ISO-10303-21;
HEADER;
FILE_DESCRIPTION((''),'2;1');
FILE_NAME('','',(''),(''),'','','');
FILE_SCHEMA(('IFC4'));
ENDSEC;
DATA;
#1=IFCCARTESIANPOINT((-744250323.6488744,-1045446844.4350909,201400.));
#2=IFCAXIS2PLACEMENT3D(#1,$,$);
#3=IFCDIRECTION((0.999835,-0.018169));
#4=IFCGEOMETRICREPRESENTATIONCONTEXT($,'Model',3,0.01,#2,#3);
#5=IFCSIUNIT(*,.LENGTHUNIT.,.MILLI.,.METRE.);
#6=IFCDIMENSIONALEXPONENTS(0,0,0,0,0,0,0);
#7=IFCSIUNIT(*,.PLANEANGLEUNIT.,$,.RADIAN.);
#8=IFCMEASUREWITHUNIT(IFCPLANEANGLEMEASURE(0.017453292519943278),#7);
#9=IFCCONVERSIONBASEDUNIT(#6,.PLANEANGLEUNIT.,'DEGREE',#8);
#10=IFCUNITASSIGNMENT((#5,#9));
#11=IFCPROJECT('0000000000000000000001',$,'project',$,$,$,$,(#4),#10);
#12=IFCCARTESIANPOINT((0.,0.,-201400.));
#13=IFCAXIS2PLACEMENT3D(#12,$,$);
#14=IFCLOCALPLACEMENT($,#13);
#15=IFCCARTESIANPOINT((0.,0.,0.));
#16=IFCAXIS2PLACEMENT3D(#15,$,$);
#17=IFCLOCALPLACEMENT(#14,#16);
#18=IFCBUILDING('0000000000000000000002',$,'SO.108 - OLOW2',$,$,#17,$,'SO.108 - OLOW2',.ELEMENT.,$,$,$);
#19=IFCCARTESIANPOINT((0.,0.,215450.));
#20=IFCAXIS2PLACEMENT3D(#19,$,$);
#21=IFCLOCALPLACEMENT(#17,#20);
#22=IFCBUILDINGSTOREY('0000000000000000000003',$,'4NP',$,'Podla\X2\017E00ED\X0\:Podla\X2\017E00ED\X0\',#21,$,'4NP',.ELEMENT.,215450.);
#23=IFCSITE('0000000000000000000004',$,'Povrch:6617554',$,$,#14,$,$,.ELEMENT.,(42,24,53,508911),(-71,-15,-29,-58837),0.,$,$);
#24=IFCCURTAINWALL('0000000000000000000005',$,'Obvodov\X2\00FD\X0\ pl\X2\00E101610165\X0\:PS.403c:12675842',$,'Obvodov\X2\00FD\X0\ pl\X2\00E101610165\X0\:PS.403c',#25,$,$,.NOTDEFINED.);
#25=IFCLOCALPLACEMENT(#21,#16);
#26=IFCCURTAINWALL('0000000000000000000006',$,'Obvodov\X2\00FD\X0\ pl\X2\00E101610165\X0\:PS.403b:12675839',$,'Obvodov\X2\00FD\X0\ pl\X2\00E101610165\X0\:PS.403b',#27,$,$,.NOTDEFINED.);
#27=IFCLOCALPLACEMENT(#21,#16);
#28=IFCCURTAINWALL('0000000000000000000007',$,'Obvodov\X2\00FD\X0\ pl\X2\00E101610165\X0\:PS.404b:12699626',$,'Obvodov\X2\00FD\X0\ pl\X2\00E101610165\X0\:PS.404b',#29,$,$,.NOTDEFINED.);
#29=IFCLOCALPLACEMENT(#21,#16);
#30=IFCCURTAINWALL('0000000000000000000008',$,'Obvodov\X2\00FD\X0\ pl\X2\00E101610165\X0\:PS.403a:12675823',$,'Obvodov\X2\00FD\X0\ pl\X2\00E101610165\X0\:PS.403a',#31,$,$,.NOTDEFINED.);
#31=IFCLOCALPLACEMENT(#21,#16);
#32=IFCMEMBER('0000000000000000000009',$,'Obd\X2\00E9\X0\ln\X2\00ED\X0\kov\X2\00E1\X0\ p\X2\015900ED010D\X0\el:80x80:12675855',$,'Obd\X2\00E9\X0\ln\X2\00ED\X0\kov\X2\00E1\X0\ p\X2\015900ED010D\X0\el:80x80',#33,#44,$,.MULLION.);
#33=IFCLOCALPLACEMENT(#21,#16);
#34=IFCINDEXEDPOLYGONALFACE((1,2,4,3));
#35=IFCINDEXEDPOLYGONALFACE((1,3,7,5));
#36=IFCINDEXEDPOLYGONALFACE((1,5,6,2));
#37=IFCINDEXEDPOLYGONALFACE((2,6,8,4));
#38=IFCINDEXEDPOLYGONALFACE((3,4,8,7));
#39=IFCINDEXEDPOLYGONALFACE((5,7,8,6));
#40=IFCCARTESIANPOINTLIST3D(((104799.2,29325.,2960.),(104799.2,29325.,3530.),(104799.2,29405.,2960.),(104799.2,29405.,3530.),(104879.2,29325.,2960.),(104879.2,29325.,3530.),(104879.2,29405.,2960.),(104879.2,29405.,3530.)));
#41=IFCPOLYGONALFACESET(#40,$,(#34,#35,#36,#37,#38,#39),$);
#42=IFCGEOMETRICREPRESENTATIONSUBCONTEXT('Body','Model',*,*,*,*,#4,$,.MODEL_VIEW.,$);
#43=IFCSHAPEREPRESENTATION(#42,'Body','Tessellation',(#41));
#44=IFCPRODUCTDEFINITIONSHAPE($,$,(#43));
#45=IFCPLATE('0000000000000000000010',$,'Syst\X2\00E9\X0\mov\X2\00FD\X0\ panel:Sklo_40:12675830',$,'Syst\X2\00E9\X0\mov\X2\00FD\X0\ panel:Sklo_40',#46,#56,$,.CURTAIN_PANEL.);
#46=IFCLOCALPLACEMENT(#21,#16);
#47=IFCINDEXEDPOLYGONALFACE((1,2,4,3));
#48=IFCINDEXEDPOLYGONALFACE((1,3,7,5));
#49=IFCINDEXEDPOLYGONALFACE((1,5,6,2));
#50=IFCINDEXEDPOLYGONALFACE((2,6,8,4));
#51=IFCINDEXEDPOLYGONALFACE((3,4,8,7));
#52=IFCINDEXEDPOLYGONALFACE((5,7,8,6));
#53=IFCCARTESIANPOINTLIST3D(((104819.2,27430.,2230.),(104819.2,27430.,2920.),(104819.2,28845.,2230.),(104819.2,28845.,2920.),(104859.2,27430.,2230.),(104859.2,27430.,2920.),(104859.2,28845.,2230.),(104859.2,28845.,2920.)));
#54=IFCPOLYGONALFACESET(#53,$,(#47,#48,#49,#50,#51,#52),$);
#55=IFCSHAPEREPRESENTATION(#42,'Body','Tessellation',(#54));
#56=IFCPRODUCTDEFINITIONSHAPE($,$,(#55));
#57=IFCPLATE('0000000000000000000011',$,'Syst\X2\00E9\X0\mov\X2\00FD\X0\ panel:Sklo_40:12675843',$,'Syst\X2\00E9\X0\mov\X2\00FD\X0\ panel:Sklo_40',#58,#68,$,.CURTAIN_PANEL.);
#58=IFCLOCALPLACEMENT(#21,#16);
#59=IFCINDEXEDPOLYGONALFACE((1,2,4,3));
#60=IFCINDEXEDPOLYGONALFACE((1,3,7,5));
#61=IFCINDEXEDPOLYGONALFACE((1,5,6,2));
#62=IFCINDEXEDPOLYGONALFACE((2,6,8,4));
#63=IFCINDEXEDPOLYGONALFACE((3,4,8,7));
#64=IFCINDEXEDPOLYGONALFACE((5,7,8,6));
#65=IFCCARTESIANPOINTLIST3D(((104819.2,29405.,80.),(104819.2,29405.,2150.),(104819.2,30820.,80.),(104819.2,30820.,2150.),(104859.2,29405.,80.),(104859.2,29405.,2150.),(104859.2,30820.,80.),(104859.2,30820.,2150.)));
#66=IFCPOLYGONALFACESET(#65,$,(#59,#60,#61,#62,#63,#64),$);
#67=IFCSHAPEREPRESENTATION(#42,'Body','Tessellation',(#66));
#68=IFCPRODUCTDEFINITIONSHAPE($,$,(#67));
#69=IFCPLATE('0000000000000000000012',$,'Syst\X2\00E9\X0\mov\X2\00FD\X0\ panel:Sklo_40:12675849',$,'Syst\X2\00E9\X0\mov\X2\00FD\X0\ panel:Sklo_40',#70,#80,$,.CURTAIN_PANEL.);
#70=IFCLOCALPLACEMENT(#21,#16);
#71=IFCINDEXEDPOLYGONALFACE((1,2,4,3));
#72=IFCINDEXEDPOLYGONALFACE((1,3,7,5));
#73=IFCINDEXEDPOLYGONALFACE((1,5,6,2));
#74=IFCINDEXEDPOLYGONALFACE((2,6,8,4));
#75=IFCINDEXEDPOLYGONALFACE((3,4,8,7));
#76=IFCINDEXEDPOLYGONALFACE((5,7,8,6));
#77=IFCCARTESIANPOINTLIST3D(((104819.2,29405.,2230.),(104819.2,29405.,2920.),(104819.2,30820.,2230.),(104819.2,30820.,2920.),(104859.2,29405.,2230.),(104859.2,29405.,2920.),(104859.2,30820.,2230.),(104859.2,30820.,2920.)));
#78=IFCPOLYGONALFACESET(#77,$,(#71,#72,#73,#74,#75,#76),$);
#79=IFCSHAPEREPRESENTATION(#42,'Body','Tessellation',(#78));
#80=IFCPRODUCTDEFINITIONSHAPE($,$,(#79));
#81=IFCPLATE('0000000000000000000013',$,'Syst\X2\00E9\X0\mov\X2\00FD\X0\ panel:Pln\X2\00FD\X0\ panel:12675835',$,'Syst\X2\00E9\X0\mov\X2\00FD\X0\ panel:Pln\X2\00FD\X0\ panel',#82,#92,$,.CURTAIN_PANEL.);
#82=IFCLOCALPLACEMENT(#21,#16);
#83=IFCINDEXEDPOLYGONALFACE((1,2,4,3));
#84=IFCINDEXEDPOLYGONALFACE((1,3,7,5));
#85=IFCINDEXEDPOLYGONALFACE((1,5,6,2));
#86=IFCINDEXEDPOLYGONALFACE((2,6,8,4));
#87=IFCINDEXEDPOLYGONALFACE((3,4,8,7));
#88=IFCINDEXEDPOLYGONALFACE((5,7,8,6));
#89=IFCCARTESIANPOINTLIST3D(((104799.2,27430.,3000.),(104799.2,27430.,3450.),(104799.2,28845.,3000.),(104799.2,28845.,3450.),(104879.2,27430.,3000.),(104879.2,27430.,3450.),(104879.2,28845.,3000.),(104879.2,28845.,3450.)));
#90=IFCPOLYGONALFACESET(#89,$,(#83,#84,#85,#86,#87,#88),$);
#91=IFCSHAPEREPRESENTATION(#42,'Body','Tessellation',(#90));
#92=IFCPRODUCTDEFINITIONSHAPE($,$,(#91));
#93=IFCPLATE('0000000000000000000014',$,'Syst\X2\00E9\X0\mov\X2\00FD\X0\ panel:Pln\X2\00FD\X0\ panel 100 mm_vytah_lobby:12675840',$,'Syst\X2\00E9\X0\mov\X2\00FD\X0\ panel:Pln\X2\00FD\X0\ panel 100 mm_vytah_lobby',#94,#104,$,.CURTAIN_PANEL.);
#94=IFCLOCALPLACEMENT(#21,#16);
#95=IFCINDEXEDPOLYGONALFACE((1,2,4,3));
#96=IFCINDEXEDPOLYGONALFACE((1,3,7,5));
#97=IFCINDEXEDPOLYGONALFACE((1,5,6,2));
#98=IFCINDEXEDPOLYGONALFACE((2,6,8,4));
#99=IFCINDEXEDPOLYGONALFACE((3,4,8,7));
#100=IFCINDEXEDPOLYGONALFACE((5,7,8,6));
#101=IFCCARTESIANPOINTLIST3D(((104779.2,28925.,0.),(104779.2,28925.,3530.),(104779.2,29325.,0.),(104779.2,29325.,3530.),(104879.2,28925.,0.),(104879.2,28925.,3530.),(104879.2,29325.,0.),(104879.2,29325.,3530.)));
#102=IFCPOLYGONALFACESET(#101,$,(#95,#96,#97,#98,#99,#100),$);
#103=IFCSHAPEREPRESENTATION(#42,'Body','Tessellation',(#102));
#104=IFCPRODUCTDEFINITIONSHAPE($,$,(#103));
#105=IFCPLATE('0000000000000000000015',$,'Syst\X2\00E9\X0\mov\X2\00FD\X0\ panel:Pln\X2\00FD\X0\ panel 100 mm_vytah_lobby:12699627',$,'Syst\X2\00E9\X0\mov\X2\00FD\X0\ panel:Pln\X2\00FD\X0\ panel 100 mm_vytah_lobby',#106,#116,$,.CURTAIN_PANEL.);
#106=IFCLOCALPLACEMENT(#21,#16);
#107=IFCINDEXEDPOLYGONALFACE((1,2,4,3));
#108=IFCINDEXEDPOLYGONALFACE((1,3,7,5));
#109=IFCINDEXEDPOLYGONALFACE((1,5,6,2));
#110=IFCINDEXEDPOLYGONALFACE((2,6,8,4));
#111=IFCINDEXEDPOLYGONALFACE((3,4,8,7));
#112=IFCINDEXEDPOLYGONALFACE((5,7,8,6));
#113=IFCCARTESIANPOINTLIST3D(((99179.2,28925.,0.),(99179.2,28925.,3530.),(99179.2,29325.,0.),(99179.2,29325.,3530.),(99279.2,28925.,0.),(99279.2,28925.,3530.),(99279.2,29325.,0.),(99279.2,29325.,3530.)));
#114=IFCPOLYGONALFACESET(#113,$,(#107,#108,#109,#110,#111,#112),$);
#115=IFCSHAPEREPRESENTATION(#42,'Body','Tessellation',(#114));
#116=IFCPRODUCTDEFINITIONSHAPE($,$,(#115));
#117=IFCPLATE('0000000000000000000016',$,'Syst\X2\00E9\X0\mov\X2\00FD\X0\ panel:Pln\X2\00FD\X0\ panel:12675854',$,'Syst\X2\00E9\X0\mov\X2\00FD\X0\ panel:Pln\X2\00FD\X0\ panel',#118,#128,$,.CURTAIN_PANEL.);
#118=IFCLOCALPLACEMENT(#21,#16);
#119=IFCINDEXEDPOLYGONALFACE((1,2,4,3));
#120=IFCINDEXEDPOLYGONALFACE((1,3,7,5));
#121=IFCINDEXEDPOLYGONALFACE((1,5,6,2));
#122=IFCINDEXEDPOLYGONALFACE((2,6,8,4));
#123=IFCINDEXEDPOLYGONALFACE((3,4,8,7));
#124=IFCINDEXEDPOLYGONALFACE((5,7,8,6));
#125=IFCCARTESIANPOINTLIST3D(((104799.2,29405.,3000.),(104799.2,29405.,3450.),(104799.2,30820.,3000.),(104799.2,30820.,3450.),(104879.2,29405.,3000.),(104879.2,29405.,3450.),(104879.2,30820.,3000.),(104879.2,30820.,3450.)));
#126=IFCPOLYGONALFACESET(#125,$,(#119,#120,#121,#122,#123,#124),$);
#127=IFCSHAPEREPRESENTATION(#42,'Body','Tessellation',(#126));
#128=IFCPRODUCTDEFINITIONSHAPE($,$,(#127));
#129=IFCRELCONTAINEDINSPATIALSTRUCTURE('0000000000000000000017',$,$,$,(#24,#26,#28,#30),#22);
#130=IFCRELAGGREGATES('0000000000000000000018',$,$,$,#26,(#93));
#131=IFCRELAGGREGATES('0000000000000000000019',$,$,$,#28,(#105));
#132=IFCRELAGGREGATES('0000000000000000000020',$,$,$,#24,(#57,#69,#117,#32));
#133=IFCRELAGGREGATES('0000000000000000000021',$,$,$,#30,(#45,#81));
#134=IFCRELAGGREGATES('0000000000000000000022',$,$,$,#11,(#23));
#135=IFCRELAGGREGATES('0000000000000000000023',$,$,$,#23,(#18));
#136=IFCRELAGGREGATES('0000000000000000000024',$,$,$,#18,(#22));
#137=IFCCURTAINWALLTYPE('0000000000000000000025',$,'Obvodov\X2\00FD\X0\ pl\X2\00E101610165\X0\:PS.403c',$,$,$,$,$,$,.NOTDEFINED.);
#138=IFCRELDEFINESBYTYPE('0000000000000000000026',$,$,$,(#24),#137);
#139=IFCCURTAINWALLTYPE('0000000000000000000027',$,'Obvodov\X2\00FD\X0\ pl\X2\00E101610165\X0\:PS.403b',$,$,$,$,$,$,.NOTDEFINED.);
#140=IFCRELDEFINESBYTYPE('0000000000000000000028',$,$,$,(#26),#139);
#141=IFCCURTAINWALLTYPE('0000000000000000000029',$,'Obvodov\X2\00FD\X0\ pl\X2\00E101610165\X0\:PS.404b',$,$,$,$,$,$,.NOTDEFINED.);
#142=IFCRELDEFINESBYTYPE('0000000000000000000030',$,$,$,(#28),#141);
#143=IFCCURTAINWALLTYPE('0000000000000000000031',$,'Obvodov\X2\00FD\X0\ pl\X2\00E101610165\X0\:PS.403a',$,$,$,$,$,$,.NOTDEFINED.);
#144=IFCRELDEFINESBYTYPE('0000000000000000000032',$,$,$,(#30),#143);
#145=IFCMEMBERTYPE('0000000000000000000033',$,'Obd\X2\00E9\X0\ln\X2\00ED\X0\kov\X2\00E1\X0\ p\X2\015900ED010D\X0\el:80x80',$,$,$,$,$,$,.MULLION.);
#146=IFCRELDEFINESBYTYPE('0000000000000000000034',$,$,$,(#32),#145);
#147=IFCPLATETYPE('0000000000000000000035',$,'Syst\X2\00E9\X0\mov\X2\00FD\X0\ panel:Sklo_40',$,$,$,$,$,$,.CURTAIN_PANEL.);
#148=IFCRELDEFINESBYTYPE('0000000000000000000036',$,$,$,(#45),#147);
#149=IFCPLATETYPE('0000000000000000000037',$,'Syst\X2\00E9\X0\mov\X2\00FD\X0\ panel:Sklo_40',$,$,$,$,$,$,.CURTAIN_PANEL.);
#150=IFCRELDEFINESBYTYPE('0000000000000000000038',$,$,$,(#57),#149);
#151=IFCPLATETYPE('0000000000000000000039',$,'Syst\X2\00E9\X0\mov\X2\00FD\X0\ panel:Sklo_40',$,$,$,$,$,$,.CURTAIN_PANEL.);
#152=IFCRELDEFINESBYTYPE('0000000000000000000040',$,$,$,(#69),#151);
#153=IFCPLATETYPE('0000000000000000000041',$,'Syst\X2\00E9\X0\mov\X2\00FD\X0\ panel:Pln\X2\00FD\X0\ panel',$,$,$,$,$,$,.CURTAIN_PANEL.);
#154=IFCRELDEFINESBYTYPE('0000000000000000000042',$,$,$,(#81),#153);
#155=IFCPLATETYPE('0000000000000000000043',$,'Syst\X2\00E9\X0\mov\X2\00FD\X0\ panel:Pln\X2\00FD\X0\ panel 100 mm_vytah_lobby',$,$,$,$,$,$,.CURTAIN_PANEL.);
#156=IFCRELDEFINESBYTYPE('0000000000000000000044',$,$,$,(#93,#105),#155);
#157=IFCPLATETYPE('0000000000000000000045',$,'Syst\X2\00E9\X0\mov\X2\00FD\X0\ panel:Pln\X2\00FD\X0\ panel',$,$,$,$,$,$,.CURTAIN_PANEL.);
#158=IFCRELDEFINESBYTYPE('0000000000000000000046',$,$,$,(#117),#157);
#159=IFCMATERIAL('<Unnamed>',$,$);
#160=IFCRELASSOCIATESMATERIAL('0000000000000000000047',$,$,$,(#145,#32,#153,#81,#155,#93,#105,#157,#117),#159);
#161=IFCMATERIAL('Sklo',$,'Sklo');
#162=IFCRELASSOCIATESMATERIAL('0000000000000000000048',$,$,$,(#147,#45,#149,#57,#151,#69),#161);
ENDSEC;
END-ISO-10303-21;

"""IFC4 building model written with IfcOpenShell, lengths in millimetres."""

from ifc_helpers import new_model, entity, si_unit, converted_unit, direction, frame, origin, place, context, subcontext, project, spatial, indexed_curve, outline, extrude, source, transform, mapped, material, type_object, type_shapes, element, aggregate, save


model = new_model("IFC4")

# Units and contexts
model_context = context("Model", 3, precision=0.01, world=frame((-744250323.6488744, -1045446844.4350909, 201400.0)), true_north=direction((0.999835, -0.018169)))
body_context = subcontext(model_context, "Body", "Model", "MODEL_VIEW")
ifc_project = project(units=[si_unit("LENGTHUNIT", "METRE", prefix="MILLI"), converted_unit("PLANEANGLEUNIT", "DEGREE", entity("IfcPlaneAngleMeasure", 0.017453292519943278), si_unit("PLANEANGLEUNIT", "RADIAN"), dimensions=[0, 0, 0, 0, 0, 0, 0])], contexts=[model_context])

# Site, building, storey
site_placement = place(None, frame((0.0, 0.0, -201400.0)))
site = spatial("IfcSite", under=ifc_project, at=site_placement, Name="Povrch:6617554", CompositionType="ELEMENT", RefLatitude=(42, 24, 53, 508911), RefLongitude=(-71, -15, -29, -58837), RefElevation=0.0)
building_placement = place(site_placement, origin())
building = spatial("IfcBuilding", under=site, at=building_placement, Name="SO.108 - OLOW2", LongName="SO.108 - OLOW2", CompositionType="ELEMENT")
storey_placement = place(building_placement, frame((0.0, 0.0, 215450.0)))
storey = spatial("IfcBuildingStorey", under=building, at=storey_placement, Name="4NP", ObjectType="Podlaží:Podlaží", LongName="4NP", CompositionType="ELEMENT", Elevation=215450.0)

# Curtain wall
curtain_wall_type_1 = type_object("IfcCurtainWallType", Name="Obvodový plášť:PS.403c", PredefinedType="NOTDEFINED")
curtain_wall_1_placement = place(storey_placement, frame((0.0, 0.0, -215450.0)))
curtain_wall_1 = element("IfcCurtainWall", 1, at=curtain_wall_1_placement, inside=storey, type_object=curtain_wall_type_1, Name="Obvodový plášť:PS.403c:12675842", ObjectType="Obvodový plášť:PS.403c", PredefinedType="NOTDEFINED")
ifc_material_1 = material(Name="<Unnamed>")

# Curtain walls
curtain_wall_type_2 = type_object("IfcCurtainWallType", Name="Obvodový plášť:PS.403b", PredefinedType="NOTDEFINED")
curtain_wall_2_placement = place(storey_placement, frame((0.0, 0.0, -215450.0)))
curtain_wall_2 = element("IfcCurtainWall", 2, at=curtain_wall_2_placement, inside=storey, type_object=curtain_wall_type_2, Name="Obvodový plášť:PS.403b:12675839", ObjectType="Obvodový plášť:PS.403b", PredefinedType="NOTDEFINED")
curtain_wall_type_3 = type_object("IfcCurtainWallType", Name="Obvodový plášť:PS.404b", PredefinedType="NOTDEFINED")
curtain_wall_3_placement = place(storey_placement, frame((0.0, 0.0, -215450.0)))
curtain_wall_3 = element("IfcCurtainWall", 3, at=curtain_wall_3_placement, inside=storey, type_object=curtain_wall_type_3, Name="Obvodový plášť:PS.404b:12699626", ObjectType="Obvodový plášť:PS.404b", PredefinedType="NOTDEFINED")

# Curtain wall
curtain_wall_type_4 = type_object("IfcCurtainWallType", Name="Obvodový plášť:PS.403a", PredefinedType="NOTDEFINED")
curtain_wall_4_placement = place(storey_placement, frame((0.0, 0.0, -215450.0)))
curtain_wall_4 = element("IfcCurtainWall", 4, at=curtain_wall_4_placement, inside=storey, type_object=curtain_wall_type_4, Name="Obvodový plášť:PS.403a:12675823", ObjectType="Obvodový plášť:PS.403a", PredefinedType="NOTDEFINED")

# Member
member_type_1 = type_object("IfcMemberType", Name="Obdélníková příčel:80x80", PredefinedType="MULLION", material=ifc_material_1)
shared_shape_1 = source(origin(), body_context, "Body", "SweptSolid", [
    extrude(outline(indexed_curve([(-40.0, -40.0), (40.0, -40.0), (40.0, 40.0), (-40.0, 40.0), (-40.0, -40.0)], self_intersect=False)), frame((-40.0, 0.0, -570.0), z_axis=(0.0, 0.0, 1.0), x_axis=(-1.0, 0.0, 0.0)), (0.0, 0.0, 1.0), 570.0),
])
type_shapes(member_type_1, [shared_shape_1])
member_1_placement = place(curtain_wall_1_placement, frame((104839.2, 29325.0, 218410.0), z_axis=(0.0, 0.0, -1.0), x_axis=(0.0, -1.0, 0.0)))
member_1 = element("IfcMember", 5, at=member_1_placement, type_object=member_type_1, material=ifc_material_1, Name="Obdélníková příčel:80x80:12675855", ObjectType="Obdélníková příčel:80x80", PredefinedType="MULLION", context=body_context, shape_type="MappedRepresentation", body=[
    mapped(shared_shape_1, transform((0.0, 0.0, 0.0), scale=1.0)),
])

# Plates
ifc_material_2 = material(Name="Sklo", Category="Sklo")
plate_type_1 = type_object("IfcPlateType", Name="Systémový panel:Sklo_40", PredefinedType="CURTAIN_PANEL", material=ifc_material_2)
shared_shape_2 = source(origin(), body_context, "Body", "SweptSolid", [
    extrude(outline(indexed_curve([(-20.0, -707.5), (20.0, -707.5), (20.0, 707.5), (-20.0, 707.5), (-20.0, -707.5)], self_intersect=False)), frame((0.0, 0.0, 0.0), z_axis=(0.0, 0.0, 1.0), x_axis=(0.0, 1.0, 0.0)), (0.0, 0.0, 1.0), 690.0),
])
type_shapes(plate_type_1, [shared_shape_2])
plate_1_placement = place(curtain_wall_4_placement, frame((104839.2, 28137.5, 217680.0), z_axis=(0.0, 0.0, 1.0), x_axis=(0.0, -1.0, 0.0)))
plate_1 = element("IfcPlate", 6, at=plate_1_placement, type_object=plate_type_1, material=ifc_material_2, Name="Systémový panel:Sklo_40:12675830", ObjectType="Systémový panel:Sklo_40", PredefinedType="CURTAIN_PANEL", context=body_context, shape_type="MappedRepresentation", body=[
    mapped(shared_shape_2, transform((0.0, 0.0, 0.0), scale=1.0)),
])
plate_type_2 = type_object("IfcPlateType", Name="Systémový panel:Sklo_40", PredefinedType="CURTAIN_PANEL", material=ifc_material_2)
shared_shape_3 = source(origin(), body_context, "Body", "SweptSolid", [
    extrude(outline(indexed_curve([(-20.0, -707.5), (20.0, -707.5), (20.0, 707.5), (-20.0, 707.5), (-20.0, -707.5)], self_intersect=False)), frame((0.0, 0.0, 0.0), z_axis=(0.0, 0.0, 1.0), x_axis=(0.0, 1.0, 0.0)), (0.0, 0.0, 1.0), 2070.0),
])
type_shapes(plate_type_2, [shared_shape_3])
plate_2_placement = place(curtain_wall_1_placement, frame((104839.2, 30112.5, 215530.0), z_axis=(0.0, 0.0, 1.0), x_axis=(0.0, -1.0, 0.0)))
plate_2 = element("IfcPlate", 7, at=plate_2_placement, type_object=plate_type_2, material=ifc_material_2, Name="Systémový panel:Sklo_40:12675843", ObjectType="Systémový panel:Sklo_40", PredefinedType="CURTAIN_PANEL", context=body_context, shape_type="MappedRepresentation", body=[
    mapped(shared_shape_3, transform((0.0, 0.0, 0.0), scale=1.0)),
])
plate_type_3 = type_object("IfcPlateType", Name="Systémový panel:Sklo_40", PredefinedType="CURTAIN_PANEL", material=ifc_material_2)
shared_shape_4 = source(origin(), body_context, "Body", "SweptSolid", [
    extrude(outline(indexed_curve([(-20.0, -707.5), (20.0, -707.5), (20.0, 707.5), (-20.0, 707.5), (-20.0, -707.5)], self_intersect=False)), frame((0.0, 0.0, 0.0), z_axis=(0.0, 0.0, 1.0), x_axis=(0.0, 1.0, 0.0)), (0.0, 0.0, 1.0), 690.0),
])
type_shapes(plate_type_3, [shared_shape_4])
plate_3_placement = place(curtain_wall_1_placement, frame((104839.2, 30112.5, 217680.0), z_axis=(0.0, 0.0, 1.0), x_axis=(0.0, -1.0, 0.0)))
plate_3 = element("IfcPlate", 8, at=plate_3_placement, type_object=plate_type_3, material=ifc_material_2, Name="Systémový panel:Sklo_40:12675849", ObjectType="Systémový panel:Sklo_40", PredefinedType="CURTAIN_PANEL", context=body_context, shape_type="MappedRepresentation", body=[
    mapped(shared_shape_4, transform((0.0, 0.0, 0.0), scale=1.0)),
])
plate_type_4 = type_object("IfcPlateType", Name="Systémový panel:Plný panel", PredefinedType="CURTAIN_PANEL", material=ifc_material_1)
shared_shape_5 = source(origin(), body_context, "Body", "SweptSolid", [
    extrude(outline(indexed_curve([(-40.0, -707.5), (40.0, -707.5), (40.0, 707.5), (-40.0, 707.5), (-40.0, -707.5)], self_intersect=False)), frame((0.0, 0.0, 0.0), z_axis=(0.0, 0.0, 1.0), x_axis=(0.0, 1.0, 0.0)), (0.0, 0.0, 1.0), 450.0),
])
type_shapes(plate_type_4, [shared_shape_5])
plate_4_placement = place(curtain_wall_4_placement, frame((104839.2, 28137.5, 218450.0), z_axis=(0.0, 0.0, 1.0), x_axis=(0.0, -1.0, 0.0)))
plate_4 = element("IfcPlate", 9, at=plate_4_placement, type_object=plate_type_4, material=ifc_material_1, Name="Systémový panel:Plný panel:12675835", ObjectType="Systémový panel:Plný panel", PredefinedType="CURTAIN_PANEL", context=body_context, shape_type="MappedRepresentation", body=[
    mapped(shared_shape_5, transform((0.0, 0.0, 0.0), scale=1.0)),
])
plate_type_5 = type_object("IfcPlateType", Name="Systémový panel:Plný panel 100 mm_vytah_lobby", PredefinedType="CURTAIN_PANEL", material=ifc_material_1)
shared_shape_6 = source(origin(), body_context, "Body", "SweptSolid", [
    extrude(outline(indexed_curve([(-50.0, -200.0), (50.0, -200.0), (50.0, 200.0), (-50.0, 200.0), (-50.0, -200.0)], self_intersect=False)), frame((0.0, 10.0, 0.0), z_axis=(0.0, 0.0, 1.0), x_axis=(0.0, 1.0, 0.0)), (0.0, 0.0, 1.0), 3530.0),
])
type_shapes(plate_type_5, [shared_shape_6])
plate_5_placement = place(curtain_wall_2_placement, frame((104839.2, 29125.0, 215450.0), z_axis=(0.0, 0.0, 1.0), x_axis=(0.0, 1.0, 0.0)))
plate_5 = element("IfcPlate", 10, at=plate_5_placement, type_object=plate_type_5, material=ifc_material_1, Name="Systémový panel:Plný panel 100 mm_vytah_lobby:12675840", ObjectType="Systémový panel:Plný panel 100 mm_vytah_lobby", PredefinedType="CURTAIN_PANEL", context=body_context, shape_type="MappedRepresentation", body=[
    mapped(shared_shape_6, transform((0.0, 0.0, 0.0), scale=1.0)),
])
aggregate(curtain_wall_2, [plate_5])
plate_6_placement = place(curtain_wall_3_placement, frame((99239.2, 29125.0, 215450.0), z_axis=(0.0, 0.0, 1.0), x_axis=(0.0, 1.0, 0.0)))
plate_6 = element("IfcPlate", 11, at=plate_6_placement, type_object=plate_type_5, material=ifc_material_1, Name="Systémový panel:Plný panel 100 mm_vytah_lobby:12699627", ObjectType="Systémový panel:Plný panel 100 mm_vytah_lobby", PredefinedType="CURTAIN_PANEL", context=body_context, shape_type="MappedRepresentation", body=[
    mapped(shared_shape_6, transform((0.0, 0.0, 0.0), scale=1.0)),
])
aggregate(curtain_wall_3, [plate_6])
plate_type_6 = type_object("IfcPlateType", Name="Systémový panel:Plný panel", PredefinedType="CURTAIN_PANEL", material=ifc_material_1)
shared_shape_7 = source(origin(), body_context, "Body", "SweptSolid", [
    extrude(outline(indexed_curve([(-40.0, -707.5), (40.0, -707.5), (40.0, 707.5), (-40.0, 707.5), (-40.0, -707.5)], self_intersect=False)), frame((0.0, 0.0, 0.0), z_axis=(0.0, 0.0, 1.0), x_axis=(0.0, 1.0, 0.0)), (0.0, 0.0, 1.0), 450.0),
])
type_shapes(plate_type_6, [shared_shape_7])
plate_7_placement = place(curtain_wall_1_placement, frame((104839.2, 30112.5, 218450.0), z_axis=(0.0, 0.0, 1.0), x_axis=(0.0, -1.0, 0.0)))
plate_7 = element("IfcPlate", 12, at=plate_7_placement, type_object=plate_type_6, material=ifc_material_1, Name="Systémový panel:Plný panel:12675854", ObjectType="Systémový panel:Plný panel", PredefinedType="CURTAIN_PANEL", context=body_context, shape_type="MappedRepresentation", body=[
    mapped(shared_shape_7, transform((0.0, 0.0, 0.0), scale=1.0)),
])
aggregate(curtain_wall_1, [plate_2, plate_3, plate_7, member_1])

aggregate(curtain_wall_4, [plate_1, plate_4])

save(model, "model.ifc")
